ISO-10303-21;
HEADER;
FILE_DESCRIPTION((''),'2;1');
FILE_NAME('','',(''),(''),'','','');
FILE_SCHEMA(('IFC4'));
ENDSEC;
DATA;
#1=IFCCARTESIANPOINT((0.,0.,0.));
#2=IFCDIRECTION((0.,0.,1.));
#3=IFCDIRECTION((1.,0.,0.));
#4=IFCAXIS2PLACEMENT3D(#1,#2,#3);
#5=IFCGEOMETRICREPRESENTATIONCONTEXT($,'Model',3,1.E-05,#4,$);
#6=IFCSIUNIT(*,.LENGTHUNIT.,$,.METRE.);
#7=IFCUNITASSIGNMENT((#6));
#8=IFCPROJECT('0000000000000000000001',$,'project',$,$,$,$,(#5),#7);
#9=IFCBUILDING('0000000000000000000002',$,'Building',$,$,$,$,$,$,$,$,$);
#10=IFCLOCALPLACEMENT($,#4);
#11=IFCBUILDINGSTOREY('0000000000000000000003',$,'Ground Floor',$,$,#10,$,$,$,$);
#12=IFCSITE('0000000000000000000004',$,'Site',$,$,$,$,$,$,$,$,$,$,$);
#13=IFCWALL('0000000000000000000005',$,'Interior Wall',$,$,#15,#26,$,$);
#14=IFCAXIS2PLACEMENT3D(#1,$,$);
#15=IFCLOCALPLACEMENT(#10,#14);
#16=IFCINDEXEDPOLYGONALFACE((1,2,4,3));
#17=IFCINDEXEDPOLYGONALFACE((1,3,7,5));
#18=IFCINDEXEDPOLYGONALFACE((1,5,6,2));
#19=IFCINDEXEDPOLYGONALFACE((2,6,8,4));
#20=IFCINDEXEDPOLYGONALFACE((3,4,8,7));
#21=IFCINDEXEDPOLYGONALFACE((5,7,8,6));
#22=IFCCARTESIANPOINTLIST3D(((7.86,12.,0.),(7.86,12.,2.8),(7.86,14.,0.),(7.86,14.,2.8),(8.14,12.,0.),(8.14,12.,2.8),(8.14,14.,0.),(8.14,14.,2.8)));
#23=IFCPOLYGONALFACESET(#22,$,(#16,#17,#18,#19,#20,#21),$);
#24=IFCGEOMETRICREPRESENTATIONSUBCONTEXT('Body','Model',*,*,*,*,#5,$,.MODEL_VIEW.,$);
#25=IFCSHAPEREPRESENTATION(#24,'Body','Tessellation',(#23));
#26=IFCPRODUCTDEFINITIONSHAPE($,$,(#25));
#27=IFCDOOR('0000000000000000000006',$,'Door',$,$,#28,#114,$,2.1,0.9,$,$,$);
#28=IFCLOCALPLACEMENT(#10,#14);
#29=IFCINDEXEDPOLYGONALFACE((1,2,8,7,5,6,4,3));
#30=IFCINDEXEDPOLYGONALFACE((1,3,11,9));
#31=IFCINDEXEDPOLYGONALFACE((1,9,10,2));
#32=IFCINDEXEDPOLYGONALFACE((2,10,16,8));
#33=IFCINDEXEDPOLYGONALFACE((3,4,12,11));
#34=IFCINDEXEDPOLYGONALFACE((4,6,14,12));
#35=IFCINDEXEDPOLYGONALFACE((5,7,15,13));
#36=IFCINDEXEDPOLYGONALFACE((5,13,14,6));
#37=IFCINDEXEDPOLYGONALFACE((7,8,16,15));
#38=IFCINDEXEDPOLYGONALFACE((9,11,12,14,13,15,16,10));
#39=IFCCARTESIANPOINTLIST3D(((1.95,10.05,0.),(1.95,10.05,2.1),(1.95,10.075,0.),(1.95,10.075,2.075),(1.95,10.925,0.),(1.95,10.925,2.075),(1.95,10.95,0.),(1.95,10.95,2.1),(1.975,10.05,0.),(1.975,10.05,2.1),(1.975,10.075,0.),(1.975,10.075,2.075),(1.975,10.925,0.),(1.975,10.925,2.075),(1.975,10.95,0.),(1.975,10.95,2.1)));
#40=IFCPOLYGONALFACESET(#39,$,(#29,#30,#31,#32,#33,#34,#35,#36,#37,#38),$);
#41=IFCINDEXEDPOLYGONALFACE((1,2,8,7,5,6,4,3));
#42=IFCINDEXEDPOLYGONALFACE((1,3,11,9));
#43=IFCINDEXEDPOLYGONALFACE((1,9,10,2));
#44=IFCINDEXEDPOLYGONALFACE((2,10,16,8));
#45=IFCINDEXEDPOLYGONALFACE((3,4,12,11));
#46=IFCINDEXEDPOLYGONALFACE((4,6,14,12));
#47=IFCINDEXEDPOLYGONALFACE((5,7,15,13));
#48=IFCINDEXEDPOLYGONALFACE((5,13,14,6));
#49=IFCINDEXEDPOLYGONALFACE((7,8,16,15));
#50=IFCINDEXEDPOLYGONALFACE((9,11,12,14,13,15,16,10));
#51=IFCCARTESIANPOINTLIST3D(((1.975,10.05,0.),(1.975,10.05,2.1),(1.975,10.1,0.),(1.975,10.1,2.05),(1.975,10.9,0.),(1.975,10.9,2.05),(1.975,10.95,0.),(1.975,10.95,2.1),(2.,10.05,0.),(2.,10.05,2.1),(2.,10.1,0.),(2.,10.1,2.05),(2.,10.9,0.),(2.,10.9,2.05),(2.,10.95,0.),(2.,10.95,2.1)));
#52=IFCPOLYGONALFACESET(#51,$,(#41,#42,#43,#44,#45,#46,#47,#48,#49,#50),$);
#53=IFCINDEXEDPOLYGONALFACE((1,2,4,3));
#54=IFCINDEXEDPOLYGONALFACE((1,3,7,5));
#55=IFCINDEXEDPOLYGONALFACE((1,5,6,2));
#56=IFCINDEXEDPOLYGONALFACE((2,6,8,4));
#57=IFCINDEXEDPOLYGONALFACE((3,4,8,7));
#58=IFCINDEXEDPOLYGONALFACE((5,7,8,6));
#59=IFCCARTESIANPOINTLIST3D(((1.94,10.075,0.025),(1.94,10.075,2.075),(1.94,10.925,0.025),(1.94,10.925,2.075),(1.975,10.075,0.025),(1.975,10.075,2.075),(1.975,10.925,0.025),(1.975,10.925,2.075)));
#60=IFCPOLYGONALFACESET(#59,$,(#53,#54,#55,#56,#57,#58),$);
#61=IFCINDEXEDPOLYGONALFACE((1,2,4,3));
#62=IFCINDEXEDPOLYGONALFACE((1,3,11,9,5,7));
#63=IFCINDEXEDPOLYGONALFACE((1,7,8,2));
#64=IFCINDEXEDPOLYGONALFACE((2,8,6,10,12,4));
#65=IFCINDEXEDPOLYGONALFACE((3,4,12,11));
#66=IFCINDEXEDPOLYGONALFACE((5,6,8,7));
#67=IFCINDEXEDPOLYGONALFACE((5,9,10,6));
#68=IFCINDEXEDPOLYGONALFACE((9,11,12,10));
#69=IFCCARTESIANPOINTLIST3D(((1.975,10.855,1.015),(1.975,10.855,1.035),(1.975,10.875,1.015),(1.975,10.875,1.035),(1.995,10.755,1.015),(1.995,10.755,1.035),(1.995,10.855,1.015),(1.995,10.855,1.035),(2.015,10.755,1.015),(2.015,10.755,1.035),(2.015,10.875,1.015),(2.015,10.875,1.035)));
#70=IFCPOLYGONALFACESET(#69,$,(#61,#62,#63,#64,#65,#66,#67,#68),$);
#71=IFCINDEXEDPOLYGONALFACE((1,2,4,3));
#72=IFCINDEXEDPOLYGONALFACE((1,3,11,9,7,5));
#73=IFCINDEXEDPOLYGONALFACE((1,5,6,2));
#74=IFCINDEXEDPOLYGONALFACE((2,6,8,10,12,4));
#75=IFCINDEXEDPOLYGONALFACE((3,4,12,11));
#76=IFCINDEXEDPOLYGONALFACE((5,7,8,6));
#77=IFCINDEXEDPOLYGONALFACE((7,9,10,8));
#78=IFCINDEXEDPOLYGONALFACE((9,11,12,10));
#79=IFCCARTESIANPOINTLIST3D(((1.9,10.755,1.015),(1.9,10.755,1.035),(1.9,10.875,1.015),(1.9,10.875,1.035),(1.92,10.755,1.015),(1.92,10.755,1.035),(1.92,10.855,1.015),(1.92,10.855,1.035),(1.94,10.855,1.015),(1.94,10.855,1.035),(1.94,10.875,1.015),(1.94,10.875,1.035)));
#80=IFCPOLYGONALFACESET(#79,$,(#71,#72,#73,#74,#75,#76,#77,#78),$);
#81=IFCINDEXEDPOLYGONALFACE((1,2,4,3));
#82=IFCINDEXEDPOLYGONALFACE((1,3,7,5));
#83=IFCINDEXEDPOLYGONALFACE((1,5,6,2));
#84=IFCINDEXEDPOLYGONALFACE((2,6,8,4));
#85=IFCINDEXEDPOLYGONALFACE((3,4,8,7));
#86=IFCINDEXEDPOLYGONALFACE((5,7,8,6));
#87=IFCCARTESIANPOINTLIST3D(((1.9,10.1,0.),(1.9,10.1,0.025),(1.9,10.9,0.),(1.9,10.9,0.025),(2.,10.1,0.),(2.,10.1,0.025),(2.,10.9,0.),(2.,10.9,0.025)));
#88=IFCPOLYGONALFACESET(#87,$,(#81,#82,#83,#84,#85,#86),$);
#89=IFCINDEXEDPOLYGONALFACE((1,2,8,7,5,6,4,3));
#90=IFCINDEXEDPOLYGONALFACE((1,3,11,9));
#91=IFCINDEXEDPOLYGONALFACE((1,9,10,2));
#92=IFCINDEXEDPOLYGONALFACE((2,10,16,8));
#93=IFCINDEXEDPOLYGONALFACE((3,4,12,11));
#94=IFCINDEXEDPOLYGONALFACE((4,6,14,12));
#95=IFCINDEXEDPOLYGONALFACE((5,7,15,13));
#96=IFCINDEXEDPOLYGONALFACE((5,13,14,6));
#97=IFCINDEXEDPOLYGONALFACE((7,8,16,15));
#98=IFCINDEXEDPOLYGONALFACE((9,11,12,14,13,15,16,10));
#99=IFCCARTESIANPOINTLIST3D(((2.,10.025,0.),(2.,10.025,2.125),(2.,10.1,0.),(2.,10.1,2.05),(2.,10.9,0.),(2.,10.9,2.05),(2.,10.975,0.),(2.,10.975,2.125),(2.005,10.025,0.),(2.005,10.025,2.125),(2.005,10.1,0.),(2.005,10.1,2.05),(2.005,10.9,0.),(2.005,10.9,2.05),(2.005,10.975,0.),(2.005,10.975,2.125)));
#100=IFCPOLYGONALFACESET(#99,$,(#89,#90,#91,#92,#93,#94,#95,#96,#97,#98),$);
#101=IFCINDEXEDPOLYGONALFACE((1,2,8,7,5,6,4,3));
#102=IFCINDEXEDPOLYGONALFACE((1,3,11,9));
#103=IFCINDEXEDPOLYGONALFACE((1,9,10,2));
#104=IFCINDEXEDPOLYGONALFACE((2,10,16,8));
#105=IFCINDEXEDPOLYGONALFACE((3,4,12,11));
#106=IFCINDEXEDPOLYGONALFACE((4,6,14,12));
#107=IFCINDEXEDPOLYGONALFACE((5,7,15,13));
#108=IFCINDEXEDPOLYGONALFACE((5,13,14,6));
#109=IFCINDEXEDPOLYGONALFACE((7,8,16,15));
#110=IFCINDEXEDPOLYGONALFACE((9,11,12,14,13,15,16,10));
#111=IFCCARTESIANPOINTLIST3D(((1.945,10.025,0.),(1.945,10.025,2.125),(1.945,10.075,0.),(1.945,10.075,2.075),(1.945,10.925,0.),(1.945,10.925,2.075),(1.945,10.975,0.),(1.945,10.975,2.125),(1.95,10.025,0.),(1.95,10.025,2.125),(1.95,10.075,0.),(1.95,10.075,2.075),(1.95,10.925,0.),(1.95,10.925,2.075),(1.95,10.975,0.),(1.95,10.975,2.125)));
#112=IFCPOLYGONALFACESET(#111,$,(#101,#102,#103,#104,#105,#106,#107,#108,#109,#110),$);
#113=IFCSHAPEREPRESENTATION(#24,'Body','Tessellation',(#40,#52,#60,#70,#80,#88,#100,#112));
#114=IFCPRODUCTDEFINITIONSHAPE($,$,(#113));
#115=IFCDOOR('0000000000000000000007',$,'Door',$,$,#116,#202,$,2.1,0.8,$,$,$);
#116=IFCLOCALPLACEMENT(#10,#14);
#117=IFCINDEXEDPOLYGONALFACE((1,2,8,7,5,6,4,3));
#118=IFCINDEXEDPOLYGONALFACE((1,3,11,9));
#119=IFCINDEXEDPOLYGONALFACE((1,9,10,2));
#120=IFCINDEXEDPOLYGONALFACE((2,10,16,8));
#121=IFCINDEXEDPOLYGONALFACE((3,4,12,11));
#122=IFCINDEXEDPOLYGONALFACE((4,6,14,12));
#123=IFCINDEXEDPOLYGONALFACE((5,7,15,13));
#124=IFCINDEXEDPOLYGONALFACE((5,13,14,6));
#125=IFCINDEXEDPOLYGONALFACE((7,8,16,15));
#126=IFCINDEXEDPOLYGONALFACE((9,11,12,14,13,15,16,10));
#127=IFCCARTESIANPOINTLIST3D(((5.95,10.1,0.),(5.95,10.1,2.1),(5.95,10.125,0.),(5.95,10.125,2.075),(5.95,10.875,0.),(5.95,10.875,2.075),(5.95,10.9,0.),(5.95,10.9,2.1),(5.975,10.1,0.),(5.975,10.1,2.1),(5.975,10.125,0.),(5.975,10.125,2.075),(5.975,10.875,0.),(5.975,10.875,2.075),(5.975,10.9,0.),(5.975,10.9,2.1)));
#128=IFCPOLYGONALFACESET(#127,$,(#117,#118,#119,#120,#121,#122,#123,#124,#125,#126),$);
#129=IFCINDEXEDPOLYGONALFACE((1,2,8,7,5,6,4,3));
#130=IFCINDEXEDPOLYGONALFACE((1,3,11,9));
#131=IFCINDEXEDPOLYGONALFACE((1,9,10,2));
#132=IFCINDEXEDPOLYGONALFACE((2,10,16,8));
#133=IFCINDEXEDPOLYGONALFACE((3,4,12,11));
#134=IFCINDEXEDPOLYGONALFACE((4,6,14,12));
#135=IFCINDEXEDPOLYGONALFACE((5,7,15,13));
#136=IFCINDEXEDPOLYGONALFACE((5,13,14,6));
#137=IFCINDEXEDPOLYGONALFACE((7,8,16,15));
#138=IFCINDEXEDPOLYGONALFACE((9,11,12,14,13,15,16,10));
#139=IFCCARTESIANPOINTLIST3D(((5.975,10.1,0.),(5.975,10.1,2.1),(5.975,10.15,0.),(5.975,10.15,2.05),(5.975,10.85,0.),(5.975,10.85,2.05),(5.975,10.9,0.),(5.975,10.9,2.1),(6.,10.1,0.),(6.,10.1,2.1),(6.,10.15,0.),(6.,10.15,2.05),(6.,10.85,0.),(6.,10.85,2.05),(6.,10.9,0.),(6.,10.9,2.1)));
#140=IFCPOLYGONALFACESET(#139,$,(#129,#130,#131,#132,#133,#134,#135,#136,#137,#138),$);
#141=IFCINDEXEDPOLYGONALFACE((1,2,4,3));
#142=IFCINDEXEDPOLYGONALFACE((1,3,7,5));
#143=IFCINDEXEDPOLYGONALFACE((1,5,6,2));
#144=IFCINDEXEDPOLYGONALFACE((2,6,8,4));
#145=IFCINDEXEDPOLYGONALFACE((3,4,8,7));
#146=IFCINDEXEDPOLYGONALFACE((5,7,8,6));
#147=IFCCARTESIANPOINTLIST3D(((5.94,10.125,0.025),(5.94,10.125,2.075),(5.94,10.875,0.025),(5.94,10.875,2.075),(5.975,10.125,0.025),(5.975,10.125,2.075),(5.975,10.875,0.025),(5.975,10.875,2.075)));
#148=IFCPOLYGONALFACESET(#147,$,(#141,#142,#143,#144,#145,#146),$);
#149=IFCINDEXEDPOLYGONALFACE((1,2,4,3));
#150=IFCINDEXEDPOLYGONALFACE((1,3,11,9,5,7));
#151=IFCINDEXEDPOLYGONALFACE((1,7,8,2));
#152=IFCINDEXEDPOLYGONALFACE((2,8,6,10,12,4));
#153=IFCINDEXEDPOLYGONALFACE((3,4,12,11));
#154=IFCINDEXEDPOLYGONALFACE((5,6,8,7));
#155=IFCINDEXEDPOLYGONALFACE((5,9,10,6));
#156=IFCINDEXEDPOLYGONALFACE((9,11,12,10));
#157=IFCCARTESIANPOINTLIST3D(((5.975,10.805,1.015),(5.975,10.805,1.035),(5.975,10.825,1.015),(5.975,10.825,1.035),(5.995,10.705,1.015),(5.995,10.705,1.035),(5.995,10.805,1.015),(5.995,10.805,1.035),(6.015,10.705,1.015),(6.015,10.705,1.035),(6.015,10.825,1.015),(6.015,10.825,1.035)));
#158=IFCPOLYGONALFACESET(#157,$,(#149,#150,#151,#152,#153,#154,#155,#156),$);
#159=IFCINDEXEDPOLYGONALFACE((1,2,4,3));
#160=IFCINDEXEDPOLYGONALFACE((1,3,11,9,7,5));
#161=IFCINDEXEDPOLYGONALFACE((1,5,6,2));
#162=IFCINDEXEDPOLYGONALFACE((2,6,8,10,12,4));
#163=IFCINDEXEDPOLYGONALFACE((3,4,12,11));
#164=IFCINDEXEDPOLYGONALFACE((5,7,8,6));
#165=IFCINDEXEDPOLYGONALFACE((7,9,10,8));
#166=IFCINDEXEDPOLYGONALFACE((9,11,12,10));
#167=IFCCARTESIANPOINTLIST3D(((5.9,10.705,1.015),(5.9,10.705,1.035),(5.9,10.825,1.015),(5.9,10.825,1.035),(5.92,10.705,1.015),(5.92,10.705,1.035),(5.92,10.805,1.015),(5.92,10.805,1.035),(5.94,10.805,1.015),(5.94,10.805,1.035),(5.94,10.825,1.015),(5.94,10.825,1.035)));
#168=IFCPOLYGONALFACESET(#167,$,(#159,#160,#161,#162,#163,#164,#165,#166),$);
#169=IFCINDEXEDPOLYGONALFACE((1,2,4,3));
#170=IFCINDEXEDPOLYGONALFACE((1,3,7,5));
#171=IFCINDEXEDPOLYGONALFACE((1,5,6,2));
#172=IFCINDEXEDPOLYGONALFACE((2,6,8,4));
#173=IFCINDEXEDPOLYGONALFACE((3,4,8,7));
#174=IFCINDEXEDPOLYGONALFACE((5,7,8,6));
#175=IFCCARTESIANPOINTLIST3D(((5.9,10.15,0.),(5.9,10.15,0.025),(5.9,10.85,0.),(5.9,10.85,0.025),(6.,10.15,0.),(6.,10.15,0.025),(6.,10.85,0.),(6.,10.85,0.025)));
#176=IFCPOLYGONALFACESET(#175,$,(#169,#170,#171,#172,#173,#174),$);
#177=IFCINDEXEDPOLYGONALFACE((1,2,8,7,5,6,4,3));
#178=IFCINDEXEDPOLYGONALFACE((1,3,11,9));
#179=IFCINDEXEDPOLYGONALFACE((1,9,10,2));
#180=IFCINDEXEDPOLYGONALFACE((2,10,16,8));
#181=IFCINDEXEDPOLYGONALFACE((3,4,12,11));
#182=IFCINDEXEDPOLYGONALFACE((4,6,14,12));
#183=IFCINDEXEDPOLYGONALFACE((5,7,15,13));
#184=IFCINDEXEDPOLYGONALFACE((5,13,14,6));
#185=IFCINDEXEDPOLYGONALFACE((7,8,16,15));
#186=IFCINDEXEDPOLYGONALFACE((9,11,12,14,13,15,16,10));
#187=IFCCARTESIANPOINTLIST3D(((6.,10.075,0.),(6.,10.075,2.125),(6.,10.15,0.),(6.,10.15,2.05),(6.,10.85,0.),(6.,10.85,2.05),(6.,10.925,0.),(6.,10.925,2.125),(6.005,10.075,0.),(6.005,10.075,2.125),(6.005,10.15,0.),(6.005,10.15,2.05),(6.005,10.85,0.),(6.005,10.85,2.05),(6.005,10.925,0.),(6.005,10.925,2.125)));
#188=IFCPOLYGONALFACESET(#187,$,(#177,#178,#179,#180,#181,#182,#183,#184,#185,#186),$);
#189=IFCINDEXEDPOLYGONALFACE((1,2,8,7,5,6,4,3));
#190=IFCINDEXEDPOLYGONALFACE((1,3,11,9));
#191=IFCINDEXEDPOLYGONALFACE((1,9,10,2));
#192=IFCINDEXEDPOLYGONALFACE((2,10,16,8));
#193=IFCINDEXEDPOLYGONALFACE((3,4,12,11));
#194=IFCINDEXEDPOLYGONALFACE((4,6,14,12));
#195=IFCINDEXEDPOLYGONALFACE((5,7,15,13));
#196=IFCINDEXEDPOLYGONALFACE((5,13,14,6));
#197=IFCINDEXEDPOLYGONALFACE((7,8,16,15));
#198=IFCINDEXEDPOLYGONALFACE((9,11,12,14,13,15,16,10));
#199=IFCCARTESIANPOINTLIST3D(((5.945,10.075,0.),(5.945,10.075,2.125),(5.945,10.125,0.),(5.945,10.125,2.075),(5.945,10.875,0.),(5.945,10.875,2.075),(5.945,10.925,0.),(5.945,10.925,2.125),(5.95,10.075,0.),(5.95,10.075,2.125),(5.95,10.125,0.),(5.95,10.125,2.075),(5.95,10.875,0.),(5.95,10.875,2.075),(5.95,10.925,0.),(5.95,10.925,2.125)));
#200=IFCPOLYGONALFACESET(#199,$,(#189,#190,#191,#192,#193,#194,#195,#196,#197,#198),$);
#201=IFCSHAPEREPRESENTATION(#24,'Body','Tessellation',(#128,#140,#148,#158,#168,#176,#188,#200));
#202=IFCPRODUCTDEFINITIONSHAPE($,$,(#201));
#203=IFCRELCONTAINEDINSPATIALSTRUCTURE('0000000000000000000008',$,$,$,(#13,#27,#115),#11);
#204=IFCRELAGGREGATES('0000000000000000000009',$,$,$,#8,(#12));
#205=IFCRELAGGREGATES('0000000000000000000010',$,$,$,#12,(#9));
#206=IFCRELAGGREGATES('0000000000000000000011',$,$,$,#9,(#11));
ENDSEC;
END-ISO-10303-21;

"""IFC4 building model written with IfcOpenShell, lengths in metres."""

from ifc_helpers import new_model, si_unit, frame, origin_with_axes, place, context, subcontext, project, spatial, line, indexed_curve, outline, extrude, element, save


model = new_model("IFC4")

# Units and contexts
model_context = context("Model", 3, precision=1e-05, world=origin_with_axes())
body_context = subcontext(model_context, "Body", "Model", "MODEL_VIEW")
ifc_project = project(units=[si_unit("LENGTHUNIT", "METRE")], contexts=[model_context])

# Site, building, storey
site = spatial("IfcSite", under=ifc_project, Name="Site")
building = spatial("IfcBuilding", under=site, Name="Building")
storey_placement = place(None, origin_with_axes())
storey = spatial("IfcBuildingStorey", under=building, at=storey_placement, Name="Ground Floor")

# Wall
for number, where, z_axis, x_axis, name in (
    (1, (8.0, 12.0, 0.0), (0.0, 0.0, 1.0), (0.0, 1.0, 0.0), "Interior Wall"),
):
    element("IfcWall", number, at=place(storey_placement, frame(where, z_axis=z_axis, x_axis=x_axis)), inside=storey, Name=name, context=body_context, shape_type="SweptSolid", body=[
        extrude(outline(indexed_curve([(0.0, 0.0), (0.0, 0.28), (2.0, 0.28), (2.0, 0.0), (0.0, 0.0)], self_intersect=False)), frame((0.0, -0.14, 0.0), z_axis=(0.0, 0.0, 1.0), x_axis=(1.0, 0.0, 0.0)), (0.0, 0.0, 1.0), 2.8),
    ])

# Doors
door_1_placement = place(storey_placement, frame((2.0, 10.05, 0.0), z_axis=(0.0, 0.0, 1.0), x_axis=(0.0, 1.0, 0.0)))
element("IfcDoor", 2, at=door_1_placement, inside=storey, Name="Door", OverallHeight=2.1, OverallWidth=0.9, context=body_context, shape_type="SweptSolid", body=[
    extrude(outline(indexed_curve([(0.0, 0.0), (0.0, 2.1), (0.9, 2.1), (0.9, 0.0), (0.875, 0.0), (0.875, 2.075), (0.025, 2.075), (0.025, 0.0)], segments=[line(1, 2, 3, 4, 5, 6, 7, 8, 1)])), frame((0.0, 0.025, 0.0), z_axis=(0.0, -1.0, 0.0), x_axis=(1.0, 0.0, 0.0)), (0.0, 0.0, -1.0), 0.025),
    extrude(outline(indexed_curve([(0.0, 0.0), (0.0, 2.1), (0.9, 2.1), (0.9, 0.0), (0.85, 0.0), (0.85, 2.05), (0.05, 2.05), (0.05, 0.0)], segments=[line(1, 2, 3, 4, 5, 6, 7, 8, 1)])), frame((0.0, 0.0, 0.0), z_axis=(0.0, -1.0, 0.0), x_axis=(1.0, 0.0, 0.0)), (0.0, 0.0, -1.0), 0.025),
    extrude(outline(indexed_curve([(0.0, 0.0), (0.85, 0.0), (0.85, 0.035), (0.0, 0.035)], segments=[line(1, 2, 3, 4, 1)])), frame((0.025, 0.025, 0.025), z_axis=(0.0, 0.0, 1.0), x_axis=(1.0, 0.0, 0.0)), (0.0, 0.0, 1.0), 2.05),
    extrude(outline(indexed_curve([(0.0, 0.0), (0.0, -0.04), (-0.12, -0.04), (-0.12, -0.02), (-0.02, -0.02), (-0.02, 0.0)], segments=[line(1, 2, 3, 4, 5, 6, 1)])), frame((0.825, 0.025, 1.015), z_axis=(0.0, 0.0, 1.0), x_axis=(1.0, 0.0, 0.0)), (0.0, 0.0, 1.0), 0.02),
    extrude(outline(indexed_curve([(0.0, 0.0), (0.0, 0.04), (-0.12, 0.04), (-0.12, 0.02), (-0.02, 0.02), (-0.02, 0.0)], segments=[line(1, 2, 3, 4, 5, 6, 1)])), frame((0.825, 0.06, 1.015), z_axis=(0.0, 0.0, 1.0), x_axis=(1.0, 0.0, 0.0)), (0.0, 0.0, 1.0), 0.02),
    extrude(outline(indexed_curve([(0.0, 0.0), (0.8, 0.0), (0.8, 0.1), (0.0, 0.1)], segments=[line(1, 2, 3, 4, 1)])), frame((0.05, 0.0, 0.0), z_axis=(0.0, 0.0, 1.0), x_axis=(1.0, 0.0, 0.0)), (0.0, 0.0, 1.0), 0.025),
    extrude(outline(indexed_curve([(0.0, 0.0), (0.0, 2.125), (0.95, 2.125), (0.95, 0.0), (0.875, 0.0), (0.875, 2.05), (0.075, 2.05), (0.075, 0.0)], segments=[line(1, 2, 3, 4, 5, 6, 7, 8, 1)])), frame((-0.025, -0.005, 0.0), z_axis=(0.0, -1.0, 0.0), x_axis=(1.0, 0.0, 0.0)), (0.0, 0.0, -1.0), 0.005),
    extrude(outline(indexed_curve([(0.0, 0.0), (0.0, 2.125), (0.95, 2.125), (0.95, 0.0), (0.9, 0.0), (0.9, 2.075), (0.05, 2.075), (0.05, 0.0)], segments=[line(1, 2, 3, 4, 5, 6, 7, 8, 1)])), frame((-0.025, 0.05, 0.0), z_axis=(0.0, -1.0, 0.0), x_axis=(1.0, 0.0, 0.0)), (0.0, 0.0, -1.0), 0.005),
])
door_2_placement = place(storey_placement, frame((6.0, 10.1, 0.0), z_axis=(0.0, 0.0, 1.0), x_axis=(0.0, 1.0, 0.0)))
element("IfcDoor", 3, at=door_2_placement, inside=storey, Name="Door", OverallHeight=2.1, OverallWidth=0.8, context=body_context, shape_type="SweptSolid", body=[
    extrude(outline(indexed_curve([(0.0, 0.0), (0.0, 2.1), (0.8, 2.1), (0.8, 0.0), (0.775, 0.0), (0.775, 2.075), (0.025, 2.075), (0.025, 0.0)], segments=[line(1, 2, 3, 4, 5, 6, 7, 8, 1)])), frame((0.0, 0.025, 0.0), z_axis=(0.0, -1.0, 0.0), x_axis=(1.0, 0.0, 0.0)), (0.0, 0.0, -1.0), 0.025),
    extrude(outline(indexed_curve([(0.0, 0.0), (0.0, 2.1), (0.8, 2.1), (0.8, 0.0), (0.75, 0.0), (0.75, 2.05), (0.05, 2.05), (0.05, 0.0)], segments=[line(1, 2, 3, 4, 5, 6, 7, 8, 1)])), frame((0.0, 0.0, 0.0), z_axis=(0.0, -1.0, 0.0), x_axis=(1.0, 0.0, 0.0)), (0.0, 0.0, -1.0), 0.025),
    extrude(outline(indexed_curve([(0.0, 0.0), (0.75, 0.0), (0.75, 0.035), (0.0, 0.035)], segments=[line(1, 2, 3, 4, 1)])), frame((0.025, 0.025, 0.025), z_axis=(0.0, 0.0, 1.0), x_axis=(1.0, 0.0, 0.0)), (0.0, 0.0, 1.0), 2.05),
    extrude(outline(indexed_curve([(0.0, 0.0), (0.0, -0.04), (-0.12, -0.04), (-0.12, -0.02), (-0.02, -0.02), (-0.02, 0.0)], segments=[line(1, 2, 3, 4, 5, 6, 1)])), frame((0.725, 0.025, 1.015), z_axis=(0.0, 0.0, 1.0), x_axis=(1.0, 0.0, 0.0)), (0.0, 0.0, 1.0), 0.02),
    extrude(outline(indexed_curve([(0.0, 0.0), (0.0, 0.04), (-0.12, 0.04), (-0.12, 0.02), (-0.02, 0.02), (-0.02, 0.0)], segments=[line(1, 2, 3, 4, 5, 6, 1)])), frame((0.725, 0.06, 1.015), z_axis=(0.0, 0.0, 1.0), x_axis=(1.0, 0.0, 0.0)), (0.0, 0.0, 1.0), 0.02),
    extrude(outline(indexed_curve([(0.0, 0.0), (0.7, 0.0), (0.7, 0.1), (0.0, 0.1)], segments=[line(1, 2, 3, 4, 1)])), frame((0.05, 0.0, 0.0), z_axis=(0.0, 0.0, 1.0), x_axis=(1.0, 0.0, 0.0)), (0.0, 0.0, 1.0), 0.025),
    extrude(outline(indexed_curve([(0.0, 0.0), (0.0, 2.125), (0.85, 2.125), (0.85, 0.0), (0.775, 0.0), (0.775, 2.05), (0.075, 2.05), (0.075, 0.0)], segments=[line(1, 2, 3, 4, 5, 6, 7, 8, 1)])), frame((-0.025, -0.005, 0.0), z_axis=(0.0, -1.0, 0.0), x_axis=(1.0, 0.0, 0.0)), (0.0, 0.0, -1.0), 0.005),
    extrude(outline(indexed_curve([(0.0, 0.0), (0.0, 2.125), (0.85, 2.125), (0.85, 0.0), (0.8, 0.0), (0.8, 2.075), (0.05, 2.075), (0.05, 0.0)], segments=[line(1, 2, 3, 4, 5, 6, 7, 8, 1)])), frame((-0.025, 0.05, 0.0), z_axis=(0.0, -1.0, 0.0), x_axis=(1.0, 0.0, 0.0)), (0.0, 0.0, -1.0), 0.005),
])

save(model, "model.ifc")
